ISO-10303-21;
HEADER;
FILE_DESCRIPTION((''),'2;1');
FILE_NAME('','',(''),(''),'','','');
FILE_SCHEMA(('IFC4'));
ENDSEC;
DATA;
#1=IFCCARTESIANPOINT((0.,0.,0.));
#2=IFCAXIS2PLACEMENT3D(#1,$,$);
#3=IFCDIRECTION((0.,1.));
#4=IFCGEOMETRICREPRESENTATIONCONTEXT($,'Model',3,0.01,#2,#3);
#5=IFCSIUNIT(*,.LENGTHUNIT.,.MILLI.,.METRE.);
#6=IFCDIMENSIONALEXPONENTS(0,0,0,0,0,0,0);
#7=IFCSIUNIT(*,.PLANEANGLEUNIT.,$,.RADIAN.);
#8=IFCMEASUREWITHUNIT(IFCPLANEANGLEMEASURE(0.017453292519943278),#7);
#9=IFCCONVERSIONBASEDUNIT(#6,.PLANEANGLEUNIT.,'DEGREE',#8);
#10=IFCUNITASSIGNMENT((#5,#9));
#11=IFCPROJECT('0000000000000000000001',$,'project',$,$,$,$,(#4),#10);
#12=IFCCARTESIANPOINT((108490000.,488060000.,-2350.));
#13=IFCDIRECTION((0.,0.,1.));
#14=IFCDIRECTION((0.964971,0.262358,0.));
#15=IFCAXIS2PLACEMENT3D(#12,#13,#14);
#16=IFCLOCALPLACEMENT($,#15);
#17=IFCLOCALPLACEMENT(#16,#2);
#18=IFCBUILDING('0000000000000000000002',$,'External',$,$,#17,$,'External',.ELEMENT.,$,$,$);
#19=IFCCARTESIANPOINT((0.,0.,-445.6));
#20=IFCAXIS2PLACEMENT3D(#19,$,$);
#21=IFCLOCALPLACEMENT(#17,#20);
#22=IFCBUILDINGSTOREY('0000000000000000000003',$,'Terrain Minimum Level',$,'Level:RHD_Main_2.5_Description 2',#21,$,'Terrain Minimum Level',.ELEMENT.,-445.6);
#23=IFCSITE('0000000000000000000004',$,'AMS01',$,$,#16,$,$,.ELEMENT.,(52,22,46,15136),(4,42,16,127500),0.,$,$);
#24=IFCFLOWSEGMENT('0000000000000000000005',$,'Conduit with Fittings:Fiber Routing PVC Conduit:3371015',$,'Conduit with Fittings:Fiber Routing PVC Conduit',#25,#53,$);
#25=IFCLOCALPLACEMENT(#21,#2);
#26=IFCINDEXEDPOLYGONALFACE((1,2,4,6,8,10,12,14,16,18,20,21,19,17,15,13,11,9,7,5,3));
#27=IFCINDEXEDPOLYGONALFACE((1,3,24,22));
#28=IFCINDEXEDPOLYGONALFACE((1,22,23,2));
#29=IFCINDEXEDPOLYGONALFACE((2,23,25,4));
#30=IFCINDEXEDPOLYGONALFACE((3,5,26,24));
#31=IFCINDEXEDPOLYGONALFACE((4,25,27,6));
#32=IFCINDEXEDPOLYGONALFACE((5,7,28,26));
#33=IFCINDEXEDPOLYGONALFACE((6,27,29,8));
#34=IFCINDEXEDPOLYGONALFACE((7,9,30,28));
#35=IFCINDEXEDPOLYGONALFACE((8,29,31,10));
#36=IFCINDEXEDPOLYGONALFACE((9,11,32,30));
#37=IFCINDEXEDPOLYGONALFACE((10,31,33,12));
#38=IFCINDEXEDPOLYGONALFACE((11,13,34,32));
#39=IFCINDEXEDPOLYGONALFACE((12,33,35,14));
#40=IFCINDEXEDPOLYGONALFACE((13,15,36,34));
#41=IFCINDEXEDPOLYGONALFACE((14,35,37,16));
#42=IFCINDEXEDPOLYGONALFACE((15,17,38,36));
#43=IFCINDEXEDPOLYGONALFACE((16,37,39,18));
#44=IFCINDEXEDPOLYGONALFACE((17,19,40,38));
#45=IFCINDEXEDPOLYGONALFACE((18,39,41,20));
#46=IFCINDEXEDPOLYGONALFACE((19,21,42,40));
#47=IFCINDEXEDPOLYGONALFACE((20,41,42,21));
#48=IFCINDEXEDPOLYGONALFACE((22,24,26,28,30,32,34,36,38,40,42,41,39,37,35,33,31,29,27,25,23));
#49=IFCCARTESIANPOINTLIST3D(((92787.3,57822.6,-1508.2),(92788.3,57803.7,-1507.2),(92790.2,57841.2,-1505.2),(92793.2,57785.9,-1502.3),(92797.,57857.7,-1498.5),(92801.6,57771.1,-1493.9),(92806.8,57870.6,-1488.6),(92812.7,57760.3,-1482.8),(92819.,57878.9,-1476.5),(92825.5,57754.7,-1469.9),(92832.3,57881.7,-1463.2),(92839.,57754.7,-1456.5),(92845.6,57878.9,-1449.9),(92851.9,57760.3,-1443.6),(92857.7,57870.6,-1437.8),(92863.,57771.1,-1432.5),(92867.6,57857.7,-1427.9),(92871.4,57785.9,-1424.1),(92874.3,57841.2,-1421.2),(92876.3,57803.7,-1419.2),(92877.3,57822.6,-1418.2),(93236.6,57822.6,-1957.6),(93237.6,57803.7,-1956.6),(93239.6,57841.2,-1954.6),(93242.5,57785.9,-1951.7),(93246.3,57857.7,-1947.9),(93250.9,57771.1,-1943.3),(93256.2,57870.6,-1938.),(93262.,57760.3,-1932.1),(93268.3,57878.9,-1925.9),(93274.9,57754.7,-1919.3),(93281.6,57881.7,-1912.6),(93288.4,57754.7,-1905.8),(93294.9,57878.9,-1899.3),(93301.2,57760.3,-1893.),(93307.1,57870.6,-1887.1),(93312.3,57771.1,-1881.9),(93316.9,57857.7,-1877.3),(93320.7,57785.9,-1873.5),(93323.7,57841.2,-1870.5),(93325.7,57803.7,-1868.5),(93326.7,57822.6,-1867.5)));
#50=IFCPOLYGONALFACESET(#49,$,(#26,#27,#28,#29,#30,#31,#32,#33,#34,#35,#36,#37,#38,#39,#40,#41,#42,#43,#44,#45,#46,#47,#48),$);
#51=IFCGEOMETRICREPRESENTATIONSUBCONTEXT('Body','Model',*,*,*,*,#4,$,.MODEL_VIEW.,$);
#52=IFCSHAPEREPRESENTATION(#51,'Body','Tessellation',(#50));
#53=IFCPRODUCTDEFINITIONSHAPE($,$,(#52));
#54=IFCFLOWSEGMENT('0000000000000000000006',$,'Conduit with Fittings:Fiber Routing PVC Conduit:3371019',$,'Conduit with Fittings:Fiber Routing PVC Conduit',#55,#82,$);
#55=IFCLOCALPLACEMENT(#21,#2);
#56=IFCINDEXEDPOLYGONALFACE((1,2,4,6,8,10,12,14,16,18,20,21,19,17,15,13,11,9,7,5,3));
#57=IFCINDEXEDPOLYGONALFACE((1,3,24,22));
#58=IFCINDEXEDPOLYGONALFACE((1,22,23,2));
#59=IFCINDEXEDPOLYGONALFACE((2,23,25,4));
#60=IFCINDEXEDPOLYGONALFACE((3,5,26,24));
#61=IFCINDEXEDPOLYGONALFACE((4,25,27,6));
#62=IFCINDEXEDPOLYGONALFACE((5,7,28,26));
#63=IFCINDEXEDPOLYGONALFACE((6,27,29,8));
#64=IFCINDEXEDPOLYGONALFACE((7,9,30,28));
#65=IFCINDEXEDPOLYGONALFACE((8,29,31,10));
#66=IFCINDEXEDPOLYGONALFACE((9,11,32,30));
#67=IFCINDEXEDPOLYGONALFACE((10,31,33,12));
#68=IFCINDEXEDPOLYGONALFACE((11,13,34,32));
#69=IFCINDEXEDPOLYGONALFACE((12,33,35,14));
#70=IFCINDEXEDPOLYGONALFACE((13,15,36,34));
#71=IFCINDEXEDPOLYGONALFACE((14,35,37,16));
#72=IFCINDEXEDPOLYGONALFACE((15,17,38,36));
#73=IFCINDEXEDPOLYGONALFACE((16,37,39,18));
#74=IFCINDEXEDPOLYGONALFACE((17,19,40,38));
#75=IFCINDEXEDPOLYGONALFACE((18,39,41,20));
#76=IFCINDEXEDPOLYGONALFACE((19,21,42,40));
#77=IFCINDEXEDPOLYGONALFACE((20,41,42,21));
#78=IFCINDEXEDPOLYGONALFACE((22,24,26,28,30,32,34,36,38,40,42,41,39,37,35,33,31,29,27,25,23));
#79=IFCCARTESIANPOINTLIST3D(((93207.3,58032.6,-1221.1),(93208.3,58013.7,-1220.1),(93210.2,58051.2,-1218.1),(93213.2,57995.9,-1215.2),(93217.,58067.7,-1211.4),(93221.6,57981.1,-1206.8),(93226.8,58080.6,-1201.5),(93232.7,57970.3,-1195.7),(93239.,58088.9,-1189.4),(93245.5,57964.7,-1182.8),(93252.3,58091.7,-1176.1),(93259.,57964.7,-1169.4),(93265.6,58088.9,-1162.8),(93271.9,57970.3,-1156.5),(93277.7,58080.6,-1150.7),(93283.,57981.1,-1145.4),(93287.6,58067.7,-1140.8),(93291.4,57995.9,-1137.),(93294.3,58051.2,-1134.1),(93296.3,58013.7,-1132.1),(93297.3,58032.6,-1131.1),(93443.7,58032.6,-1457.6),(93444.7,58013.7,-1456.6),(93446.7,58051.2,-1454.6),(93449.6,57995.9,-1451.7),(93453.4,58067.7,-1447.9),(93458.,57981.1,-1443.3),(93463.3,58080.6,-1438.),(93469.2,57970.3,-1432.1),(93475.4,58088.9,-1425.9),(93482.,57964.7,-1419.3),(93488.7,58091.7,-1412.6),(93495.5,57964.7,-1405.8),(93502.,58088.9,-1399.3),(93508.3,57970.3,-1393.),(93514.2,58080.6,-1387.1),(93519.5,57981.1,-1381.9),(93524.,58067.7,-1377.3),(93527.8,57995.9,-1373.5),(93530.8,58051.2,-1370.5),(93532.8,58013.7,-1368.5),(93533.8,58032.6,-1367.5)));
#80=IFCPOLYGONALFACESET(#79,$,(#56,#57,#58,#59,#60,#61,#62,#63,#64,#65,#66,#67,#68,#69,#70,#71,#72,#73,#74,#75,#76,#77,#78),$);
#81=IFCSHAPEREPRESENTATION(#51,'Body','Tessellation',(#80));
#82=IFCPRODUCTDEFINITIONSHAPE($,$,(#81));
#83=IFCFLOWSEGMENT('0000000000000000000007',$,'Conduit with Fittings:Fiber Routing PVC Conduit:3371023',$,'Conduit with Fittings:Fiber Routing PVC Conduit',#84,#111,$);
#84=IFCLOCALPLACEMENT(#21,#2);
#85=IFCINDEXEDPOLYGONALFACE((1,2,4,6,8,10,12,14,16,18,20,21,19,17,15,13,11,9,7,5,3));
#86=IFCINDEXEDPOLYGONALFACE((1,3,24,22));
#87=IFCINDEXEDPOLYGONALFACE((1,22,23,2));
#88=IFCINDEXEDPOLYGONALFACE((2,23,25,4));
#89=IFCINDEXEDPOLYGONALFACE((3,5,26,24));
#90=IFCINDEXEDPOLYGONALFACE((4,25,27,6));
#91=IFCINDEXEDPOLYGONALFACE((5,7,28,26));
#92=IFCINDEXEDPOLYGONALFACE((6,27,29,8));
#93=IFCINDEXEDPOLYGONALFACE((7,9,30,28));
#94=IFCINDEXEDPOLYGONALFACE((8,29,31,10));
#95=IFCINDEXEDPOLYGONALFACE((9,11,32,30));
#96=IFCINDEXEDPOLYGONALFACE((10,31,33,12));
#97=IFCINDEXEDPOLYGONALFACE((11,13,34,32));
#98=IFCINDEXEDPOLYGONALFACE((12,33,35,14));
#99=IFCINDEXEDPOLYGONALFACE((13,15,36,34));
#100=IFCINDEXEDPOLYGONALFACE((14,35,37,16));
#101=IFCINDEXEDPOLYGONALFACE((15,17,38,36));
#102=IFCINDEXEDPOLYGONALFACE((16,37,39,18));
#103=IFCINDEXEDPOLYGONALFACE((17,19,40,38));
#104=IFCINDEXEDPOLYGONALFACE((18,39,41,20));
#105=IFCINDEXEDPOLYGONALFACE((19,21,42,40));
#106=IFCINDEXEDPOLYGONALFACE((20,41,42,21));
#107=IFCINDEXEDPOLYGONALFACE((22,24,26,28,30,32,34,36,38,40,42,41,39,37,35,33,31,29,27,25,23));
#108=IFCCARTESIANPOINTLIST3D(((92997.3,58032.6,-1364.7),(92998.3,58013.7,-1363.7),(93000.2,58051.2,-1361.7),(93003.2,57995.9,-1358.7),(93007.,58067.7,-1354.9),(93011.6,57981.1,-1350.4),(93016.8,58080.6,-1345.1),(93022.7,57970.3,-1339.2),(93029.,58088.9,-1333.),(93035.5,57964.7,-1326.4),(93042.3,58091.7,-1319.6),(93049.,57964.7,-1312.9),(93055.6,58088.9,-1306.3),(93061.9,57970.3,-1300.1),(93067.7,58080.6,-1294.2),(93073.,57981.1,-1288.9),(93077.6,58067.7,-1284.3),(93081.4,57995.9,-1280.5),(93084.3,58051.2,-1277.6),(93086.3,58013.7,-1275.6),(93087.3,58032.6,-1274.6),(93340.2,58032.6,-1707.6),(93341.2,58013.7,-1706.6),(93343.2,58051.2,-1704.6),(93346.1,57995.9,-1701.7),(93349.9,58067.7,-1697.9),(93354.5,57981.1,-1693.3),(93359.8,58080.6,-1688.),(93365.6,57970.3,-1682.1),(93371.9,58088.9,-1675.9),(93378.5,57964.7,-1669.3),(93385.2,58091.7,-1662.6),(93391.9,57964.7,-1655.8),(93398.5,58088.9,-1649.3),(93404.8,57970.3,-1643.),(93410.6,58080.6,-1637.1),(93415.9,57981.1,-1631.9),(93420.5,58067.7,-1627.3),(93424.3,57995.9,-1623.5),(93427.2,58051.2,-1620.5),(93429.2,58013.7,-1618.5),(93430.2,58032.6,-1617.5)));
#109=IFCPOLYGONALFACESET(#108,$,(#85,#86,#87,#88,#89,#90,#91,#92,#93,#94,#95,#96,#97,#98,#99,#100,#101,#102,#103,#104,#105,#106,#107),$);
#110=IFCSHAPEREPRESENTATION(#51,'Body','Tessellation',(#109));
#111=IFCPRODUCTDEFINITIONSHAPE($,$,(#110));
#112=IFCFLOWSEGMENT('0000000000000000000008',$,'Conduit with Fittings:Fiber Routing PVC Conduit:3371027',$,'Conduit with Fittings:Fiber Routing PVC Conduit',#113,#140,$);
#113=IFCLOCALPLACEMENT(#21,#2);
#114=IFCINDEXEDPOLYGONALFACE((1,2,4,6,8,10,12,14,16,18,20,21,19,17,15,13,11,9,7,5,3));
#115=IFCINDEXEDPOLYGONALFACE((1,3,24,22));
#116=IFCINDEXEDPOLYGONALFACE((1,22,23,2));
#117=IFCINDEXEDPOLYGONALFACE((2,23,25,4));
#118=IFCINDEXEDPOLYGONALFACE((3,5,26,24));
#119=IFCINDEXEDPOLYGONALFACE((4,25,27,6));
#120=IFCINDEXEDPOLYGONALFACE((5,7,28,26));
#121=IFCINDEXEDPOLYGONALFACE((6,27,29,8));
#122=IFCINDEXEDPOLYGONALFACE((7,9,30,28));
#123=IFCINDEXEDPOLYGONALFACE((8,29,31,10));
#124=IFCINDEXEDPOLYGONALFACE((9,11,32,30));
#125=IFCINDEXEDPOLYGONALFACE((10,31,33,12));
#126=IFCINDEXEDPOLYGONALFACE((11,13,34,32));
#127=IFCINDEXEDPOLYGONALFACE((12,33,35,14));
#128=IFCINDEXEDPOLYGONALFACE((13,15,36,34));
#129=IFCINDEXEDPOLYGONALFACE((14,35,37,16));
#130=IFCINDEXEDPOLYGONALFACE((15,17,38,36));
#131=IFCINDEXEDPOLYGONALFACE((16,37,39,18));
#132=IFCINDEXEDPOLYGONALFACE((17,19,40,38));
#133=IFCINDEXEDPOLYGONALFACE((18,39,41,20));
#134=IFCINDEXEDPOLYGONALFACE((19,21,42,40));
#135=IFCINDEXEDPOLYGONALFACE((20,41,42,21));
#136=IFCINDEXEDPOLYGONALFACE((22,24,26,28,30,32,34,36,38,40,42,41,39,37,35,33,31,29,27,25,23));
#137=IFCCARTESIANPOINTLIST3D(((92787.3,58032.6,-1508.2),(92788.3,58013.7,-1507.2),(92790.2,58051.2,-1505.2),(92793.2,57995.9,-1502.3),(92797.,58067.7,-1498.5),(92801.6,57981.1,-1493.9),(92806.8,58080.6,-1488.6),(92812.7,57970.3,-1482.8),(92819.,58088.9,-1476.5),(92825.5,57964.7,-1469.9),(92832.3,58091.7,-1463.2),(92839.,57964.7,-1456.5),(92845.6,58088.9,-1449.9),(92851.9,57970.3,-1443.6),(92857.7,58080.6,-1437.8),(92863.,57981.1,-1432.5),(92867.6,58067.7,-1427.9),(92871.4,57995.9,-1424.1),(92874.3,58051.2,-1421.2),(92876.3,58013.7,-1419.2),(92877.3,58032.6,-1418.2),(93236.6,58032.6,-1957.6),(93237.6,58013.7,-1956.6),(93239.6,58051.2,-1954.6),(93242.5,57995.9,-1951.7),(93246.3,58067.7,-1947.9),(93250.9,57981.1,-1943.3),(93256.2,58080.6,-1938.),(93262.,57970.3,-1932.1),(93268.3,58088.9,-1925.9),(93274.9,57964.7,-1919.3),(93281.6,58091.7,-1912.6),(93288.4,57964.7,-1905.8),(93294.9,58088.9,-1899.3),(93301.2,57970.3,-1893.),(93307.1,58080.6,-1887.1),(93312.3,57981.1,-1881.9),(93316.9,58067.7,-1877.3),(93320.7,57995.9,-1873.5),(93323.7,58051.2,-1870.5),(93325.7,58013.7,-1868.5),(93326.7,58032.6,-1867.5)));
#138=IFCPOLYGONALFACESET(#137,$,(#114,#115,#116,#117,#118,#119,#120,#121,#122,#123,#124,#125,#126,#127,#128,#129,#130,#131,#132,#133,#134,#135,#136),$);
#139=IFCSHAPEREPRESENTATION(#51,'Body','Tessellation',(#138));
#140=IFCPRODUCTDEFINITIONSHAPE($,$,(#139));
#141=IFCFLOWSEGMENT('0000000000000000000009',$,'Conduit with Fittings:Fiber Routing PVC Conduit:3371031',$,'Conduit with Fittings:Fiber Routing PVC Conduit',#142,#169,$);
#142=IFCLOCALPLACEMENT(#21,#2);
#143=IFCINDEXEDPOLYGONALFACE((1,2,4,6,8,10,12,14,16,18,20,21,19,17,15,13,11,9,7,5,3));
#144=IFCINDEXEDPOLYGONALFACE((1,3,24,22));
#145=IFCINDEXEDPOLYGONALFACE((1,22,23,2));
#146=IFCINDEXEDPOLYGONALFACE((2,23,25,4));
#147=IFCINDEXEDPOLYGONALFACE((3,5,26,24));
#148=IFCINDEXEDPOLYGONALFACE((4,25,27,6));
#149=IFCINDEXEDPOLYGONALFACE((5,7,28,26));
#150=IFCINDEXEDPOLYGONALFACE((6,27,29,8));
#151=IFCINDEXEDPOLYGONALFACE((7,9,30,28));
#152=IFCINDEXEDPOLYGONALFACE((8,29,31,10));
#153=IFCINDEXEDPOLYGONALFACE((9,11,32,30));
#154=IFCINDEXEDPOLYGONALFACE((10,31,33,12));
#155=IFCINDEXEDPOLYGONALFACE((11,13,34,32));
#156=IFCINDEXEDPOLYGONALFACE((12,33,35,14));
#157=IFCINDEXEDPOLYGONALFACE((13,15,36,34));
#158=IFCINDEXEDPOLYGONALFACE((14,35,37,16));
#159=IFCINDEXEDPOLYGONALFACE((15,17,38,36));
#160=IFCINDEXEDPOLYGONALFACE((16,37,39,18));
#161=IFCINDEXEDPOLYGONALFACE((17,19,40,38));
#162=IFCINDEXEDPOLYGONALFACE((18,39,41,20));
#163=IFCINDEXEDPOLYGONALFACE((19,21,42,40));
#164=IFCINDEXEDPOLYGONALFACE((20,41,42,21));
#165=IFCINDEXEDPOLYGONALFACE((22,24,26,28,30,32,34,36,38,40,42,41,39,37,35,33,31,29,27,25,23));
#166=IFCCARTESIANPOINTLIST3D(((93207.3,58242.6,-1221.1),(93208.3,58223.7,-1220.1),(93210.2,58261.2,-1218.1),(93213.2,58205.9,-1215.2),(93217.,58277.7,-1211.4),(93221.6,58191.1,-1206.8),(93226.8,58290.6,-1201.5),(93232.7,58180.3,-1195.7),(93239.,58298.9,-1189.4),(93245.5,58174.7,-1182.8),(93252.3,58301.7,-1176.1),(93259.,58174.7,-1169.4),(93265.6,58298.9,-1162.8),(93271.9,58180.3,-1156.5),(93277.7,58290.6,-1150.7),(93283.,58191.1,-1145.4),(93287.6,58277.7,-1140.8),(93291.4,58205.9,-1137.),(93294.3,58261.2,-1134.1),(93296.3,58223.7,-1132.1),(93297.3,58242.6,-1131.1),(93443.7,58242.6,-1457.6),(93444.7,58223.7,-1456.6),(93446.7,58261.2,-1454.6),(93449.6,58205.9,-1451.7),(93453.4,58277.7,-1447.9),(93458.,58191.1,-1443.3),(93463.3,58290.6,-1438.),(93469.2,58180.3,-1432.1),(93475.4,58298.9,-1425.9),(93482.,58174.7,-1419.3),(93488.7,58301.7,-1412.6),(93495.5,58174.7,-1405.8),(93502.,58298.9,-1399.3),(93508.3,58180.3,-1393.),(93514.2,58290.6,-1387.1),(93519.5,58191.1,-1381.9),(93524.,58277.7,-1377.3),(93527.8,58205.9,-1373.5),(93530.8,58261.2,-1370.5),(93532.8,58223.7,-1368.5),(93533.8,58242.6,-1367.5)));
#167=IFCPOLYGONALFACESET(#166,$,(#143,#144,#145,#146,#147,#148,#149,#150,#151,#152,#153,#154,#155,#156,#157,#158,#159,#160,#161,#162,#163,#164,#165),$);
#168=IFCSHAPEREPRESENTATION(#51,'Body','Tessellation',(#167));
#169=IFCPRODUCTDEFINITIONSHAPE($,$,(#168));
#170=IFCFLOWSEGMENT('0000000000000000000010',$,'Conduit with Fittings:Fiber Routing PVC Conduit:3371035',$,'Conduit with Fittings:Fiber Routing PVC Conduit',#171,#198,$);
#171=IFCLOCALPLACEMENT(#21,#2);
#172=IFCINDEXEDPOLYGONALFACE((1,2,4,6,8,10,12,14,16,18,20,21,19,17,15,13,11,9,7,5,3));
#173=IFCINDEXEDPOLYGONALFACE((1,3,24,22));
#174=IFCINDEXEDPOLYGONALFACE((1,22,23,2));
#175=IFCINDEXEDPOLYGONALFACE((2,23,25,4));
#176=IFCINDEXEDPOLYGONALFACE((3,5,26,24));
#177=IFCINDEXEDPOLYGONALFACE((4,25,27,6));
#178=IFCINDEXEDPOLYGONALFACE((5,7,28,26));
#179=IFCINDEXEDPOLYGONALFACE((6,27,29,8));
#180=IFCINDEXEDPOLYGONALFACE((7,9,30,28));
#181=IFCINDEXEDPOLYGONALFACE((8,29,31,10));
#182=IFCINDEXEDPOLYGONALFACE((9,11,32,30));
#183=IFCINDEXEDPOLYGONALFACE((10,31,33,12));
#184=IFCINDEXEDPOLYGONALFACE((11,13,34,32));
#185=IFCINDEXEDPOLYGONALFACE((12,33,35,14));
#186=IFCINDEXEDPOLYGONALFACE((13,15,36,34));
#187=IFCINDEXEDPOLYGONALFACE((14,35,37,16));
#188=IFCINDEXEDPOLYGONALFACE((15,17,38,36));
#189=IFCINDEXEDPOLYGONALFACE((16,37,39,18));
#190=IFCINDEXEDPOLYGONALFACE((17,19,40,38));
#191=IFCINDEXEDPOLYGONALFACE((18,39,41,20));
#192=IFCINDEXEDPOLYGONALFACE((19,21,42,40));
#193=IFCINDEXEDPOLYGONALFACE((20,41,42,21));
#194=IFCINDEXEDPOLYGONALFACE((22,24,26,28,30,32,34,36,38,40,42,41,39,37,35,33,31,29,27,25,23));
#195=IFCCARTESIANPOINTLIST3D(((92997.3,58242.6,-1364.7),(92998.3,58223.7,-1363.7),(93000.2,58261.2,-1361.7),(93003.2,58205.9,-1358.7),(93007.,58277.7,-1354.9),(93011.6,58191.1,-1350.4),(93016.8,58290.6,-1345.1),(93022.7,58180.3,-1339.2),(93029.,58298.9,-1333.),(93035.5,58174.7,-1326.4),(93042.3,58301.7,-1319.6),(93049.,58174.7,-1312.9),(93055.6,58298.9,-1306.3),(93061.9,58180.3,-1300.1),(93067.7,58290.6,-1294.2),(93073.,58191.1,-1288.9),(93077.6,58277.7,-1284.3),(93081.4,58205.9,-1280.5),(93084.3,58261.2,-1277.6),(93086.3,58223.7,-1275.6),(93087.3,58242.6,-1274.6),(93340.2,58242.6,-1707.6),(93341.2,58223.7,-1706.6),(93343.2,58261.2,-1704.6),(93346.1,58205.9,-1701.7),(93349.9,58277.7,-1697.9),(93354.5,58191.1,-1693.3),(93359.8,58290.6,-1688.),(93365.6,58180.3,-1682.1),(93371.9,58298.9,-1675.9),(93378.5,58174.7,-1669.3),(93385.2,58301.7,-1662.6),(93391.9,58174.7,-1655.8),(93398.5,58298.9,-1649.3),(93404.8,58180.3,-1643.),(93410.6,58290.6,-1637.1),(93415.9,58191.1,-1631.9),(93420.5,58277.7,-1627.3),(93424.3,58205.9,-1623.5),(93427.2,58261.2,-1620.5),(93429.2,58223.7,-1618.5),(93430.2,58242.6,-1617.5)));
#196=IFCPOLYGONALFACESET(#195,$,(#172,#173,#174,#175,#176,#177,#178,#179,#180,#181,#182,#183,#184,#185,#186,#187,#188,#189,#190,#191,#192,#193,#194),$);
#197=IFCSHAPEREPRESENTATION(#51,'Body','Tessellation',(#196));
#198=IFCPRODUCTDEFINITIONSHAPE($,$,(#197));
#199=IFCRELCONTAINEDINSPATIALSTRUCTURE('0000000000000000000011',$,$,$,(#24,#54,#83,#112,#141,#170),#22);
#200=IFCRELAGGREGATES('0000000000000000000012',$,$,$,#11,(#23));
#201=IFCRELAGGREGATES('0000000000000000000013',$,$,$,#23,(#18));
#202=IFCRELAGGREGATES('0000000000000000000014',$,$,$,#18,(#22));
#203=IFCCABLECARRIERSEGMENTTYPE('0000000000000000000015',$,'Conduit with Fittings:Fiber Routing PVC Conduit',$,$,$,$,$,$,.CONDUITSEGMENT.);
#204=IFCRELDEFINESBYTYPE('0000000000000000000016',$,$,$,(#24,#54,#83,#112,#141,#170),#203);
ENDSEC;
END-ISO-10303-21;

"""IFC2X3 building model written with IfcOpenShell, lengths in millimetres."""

from ifc_helpers import new_model, entity, si_unit, converted_unit, direction, frame, frame_2d, origin, origin_2d_with_axis, place, context, subcontext, project, spatial, circle, extrude, type_object, element, save


model = new_model("IFC2X3")

# Units and contexts
model_context = context("Model", 3, precision=0.01, world=origin(), true_north=direction((0.0, 1.0)))
body_context = subcontext(model_context, "Body", "Model", "MODEL_VIEW")
ifc_project = project(units=[si_unit("LENGTHUNIT", "METRE", prefix="MILLI"), converted_unit("PLANEANGLEUNIT", "DEGREE", entity("IfcPlaneAngleMeasure", 0.017453292519943278), si_unit("PLANEANGLEUNIT", "RADIAN"), dimensions=[0, 0, 0, 0, 0, 0, 0])], contexts=[model_context])

# Site, building, storey
site_placement = place(None, frame((108490000.0, 488060000.0, -2350.0), z_axis=(0.0, 0.0, 1.0), x_axis=(0.964971, 0.262358, 0.0)))
site = spatial("IfcSite", under=ifc_project, at=site_placement, Name="AMS01", CompositionType="ELEMENT", RefLatitude=(52, 22, 46, 15136), RefLongitude=(4, 42, 16, 127500), RefElevation=0.0)
building_placement = place(site_placement, origin())
building = spatial("IfcBuilding", under=site, at=building_placement, Name="External", LongName="External", CompositionType="ELEMENT")
storey_placement = place(building_placement, frame((0.0, 0.0, -445.6)))
storey = spatial("IfcBuildingStorey", under=building, at=storey_placement, Name="Terrain Minimum Level", ObjectType="Level:RHD_Main_2.5_Description 2", LongName="Terrain Minimum Level", CompositionType="ELEMENT", Elevation=-445.6)

# Flow segments
cable_carrier_segment_type = type_object("IfcCableCarrierSegmentType", Name="Conduit with Fittings:Fiber Routing PVC Conduit", PredefinedType="CONDUITSEGMENT")
flow_segment_1_placement = place(storey_placement, origin())
element("IfcFlowSegment", 1, at=flow_segment_1_placement, inside=storey, type_object=cable_carrier_segment_type, Name="Conduit with Fittings:Fiber Routing PVC Conduit:3371015", ObjectType="Conduit with Fittings:Fiber Routing PVC Conduit", context=body_context, shape_type="SweptSolid", body=[
    extrude(circle(Radius=63.9, at=frame_2d((0.0, 0.0), x_axis=(1.0, 0.0))), frame((93281.6, 57817.9, -1912.6), z_axis=(-0.707107, 0.0, 0.707107), x_axis=(0.0, 1.0, 0.0)), (0.0, 0.0, 1.0), 635.5),
])
flow_segment_2_placement = place(storey_placement, origin())
element("IfcFlowSegment", 2, at=flow_segment_2_placement, inside=storey, type_object=cable_carrier_segment_type, Name="Conduit with Fittings:Fiber Routing PVC Conduit:3371019", ObjectType="Conduit with Fittings:Fiber Routing PVC Conduit", context=body_context, shape_type="SweptSolid", body=[
    extrude(circle(Radius=63.9, at=frame_2d((0.0, 0.0), x_axis=(1.0, 0.0))), frame((93252.3, 58027.9, -1176.1), z_axis=(0.707107, 0.0, -0.707107), x_axis=(0.0, 1.0, 0.0)), (0.0, 0.0, 1.0), 334.4),
])
flow_segment_3_placement = place(storey_placement, origin())
element("IfcFlowSegment", 3, at=flow_segment_3_placement, inside=storey, type_object=cable_carrier_segment_type, Name="Conduit with Fittings:Fiber Routing PVC Conduit:3371023", ObjectType="Conduit with Fittings:Fiber Routing PVC Conduit", context=body_context, shape_type="SweptSolid", body=[
    extrude(circle(Radius=63.9, at=frame_2d((0.0, 0.0), x_axis=(1.0, 0.0))), frame((93385.2, 58027.9, -1662.6), z_axis=(-0.707107, 0.0, 0.707107), x_axis=(0.0, 1.0, 0.0)), (0.0, 0.0, 1.0), 485.0),
])
flow_segment_4_placement = place(storey_placement, origin())
element("IfcFlowSegment", 4, at=flow_segment_4_placement, inside=storey, type_object=cable_carrier_segment_type, Name="Conduit with Fittings:Fiber Routing PVC Conduit:3371027", ObjectType="Conduit with Fittings:Fiber Routing PVC Conduit", context=body_context, shape_type="SweptSolid", body=[
    extrude(circle(Radius=63.9, at=frame_2d((0.0, 0.0), x_axis=(1.0, 0.0))), frame((93281.6, 58027.9, -1912.6), z_axis=(-0.707107, 0.0, 0.707107), x_axis=(0.0, 1.0, 0.0)), (0.0, 0.0, 1.0), 635.5),
])
flow_segment_5_placement = place(storey_placement, origin())
element("IfcFlowSegment", 5, at=flow_segment_5_placement, inside=storey, type_object=cable_carrier_segment_type, Name="Conduit with Fittings:Fiber Routing PVC Conduit:3371031", ObjectType="Conduit with Fittings:Fiber Routing PVC Conduit", context=body_context, shape_type="SweptSolid", body=[
    extrude(circle(Radius=63.9, at=frame_2d((0.0, 0.0), x_axis=(1.0, 0.0))), frame((93252.3, 58237.9, -1176.1), z_axis=(0.707107, 0.0, -0.707107), x_axis=(0.0, 1.0, 0.0)), (0.0, 0.0, 1.0), 334.4),
])
flow_segment_6_placement = place(storey_placement, origin())
element("IfcFlowSegment", 6, at=flow_segment_6_placement, inside=storey, type_object=cable_carrier_segment_type, Name="Conduit with Fittings:Fiber Routing PVC Conduit:3371035", ObjectType="Conduit with Fittings:Fiber Routing PVC Conduit", context=body_context, shape_type="SweptSolid", body=[
    extrude(circle(Radius=63.9, at=origin_2d_with_axis()), frame((93042.3, 58237.9, -1319.6), z_axis=(0.707107, 0.0, -0.707107), x_axis=(0.0, 1.0, 0.0)), (0.0, 0.0, 1.0), 485.0),
])

save(model, "model.ifc")
